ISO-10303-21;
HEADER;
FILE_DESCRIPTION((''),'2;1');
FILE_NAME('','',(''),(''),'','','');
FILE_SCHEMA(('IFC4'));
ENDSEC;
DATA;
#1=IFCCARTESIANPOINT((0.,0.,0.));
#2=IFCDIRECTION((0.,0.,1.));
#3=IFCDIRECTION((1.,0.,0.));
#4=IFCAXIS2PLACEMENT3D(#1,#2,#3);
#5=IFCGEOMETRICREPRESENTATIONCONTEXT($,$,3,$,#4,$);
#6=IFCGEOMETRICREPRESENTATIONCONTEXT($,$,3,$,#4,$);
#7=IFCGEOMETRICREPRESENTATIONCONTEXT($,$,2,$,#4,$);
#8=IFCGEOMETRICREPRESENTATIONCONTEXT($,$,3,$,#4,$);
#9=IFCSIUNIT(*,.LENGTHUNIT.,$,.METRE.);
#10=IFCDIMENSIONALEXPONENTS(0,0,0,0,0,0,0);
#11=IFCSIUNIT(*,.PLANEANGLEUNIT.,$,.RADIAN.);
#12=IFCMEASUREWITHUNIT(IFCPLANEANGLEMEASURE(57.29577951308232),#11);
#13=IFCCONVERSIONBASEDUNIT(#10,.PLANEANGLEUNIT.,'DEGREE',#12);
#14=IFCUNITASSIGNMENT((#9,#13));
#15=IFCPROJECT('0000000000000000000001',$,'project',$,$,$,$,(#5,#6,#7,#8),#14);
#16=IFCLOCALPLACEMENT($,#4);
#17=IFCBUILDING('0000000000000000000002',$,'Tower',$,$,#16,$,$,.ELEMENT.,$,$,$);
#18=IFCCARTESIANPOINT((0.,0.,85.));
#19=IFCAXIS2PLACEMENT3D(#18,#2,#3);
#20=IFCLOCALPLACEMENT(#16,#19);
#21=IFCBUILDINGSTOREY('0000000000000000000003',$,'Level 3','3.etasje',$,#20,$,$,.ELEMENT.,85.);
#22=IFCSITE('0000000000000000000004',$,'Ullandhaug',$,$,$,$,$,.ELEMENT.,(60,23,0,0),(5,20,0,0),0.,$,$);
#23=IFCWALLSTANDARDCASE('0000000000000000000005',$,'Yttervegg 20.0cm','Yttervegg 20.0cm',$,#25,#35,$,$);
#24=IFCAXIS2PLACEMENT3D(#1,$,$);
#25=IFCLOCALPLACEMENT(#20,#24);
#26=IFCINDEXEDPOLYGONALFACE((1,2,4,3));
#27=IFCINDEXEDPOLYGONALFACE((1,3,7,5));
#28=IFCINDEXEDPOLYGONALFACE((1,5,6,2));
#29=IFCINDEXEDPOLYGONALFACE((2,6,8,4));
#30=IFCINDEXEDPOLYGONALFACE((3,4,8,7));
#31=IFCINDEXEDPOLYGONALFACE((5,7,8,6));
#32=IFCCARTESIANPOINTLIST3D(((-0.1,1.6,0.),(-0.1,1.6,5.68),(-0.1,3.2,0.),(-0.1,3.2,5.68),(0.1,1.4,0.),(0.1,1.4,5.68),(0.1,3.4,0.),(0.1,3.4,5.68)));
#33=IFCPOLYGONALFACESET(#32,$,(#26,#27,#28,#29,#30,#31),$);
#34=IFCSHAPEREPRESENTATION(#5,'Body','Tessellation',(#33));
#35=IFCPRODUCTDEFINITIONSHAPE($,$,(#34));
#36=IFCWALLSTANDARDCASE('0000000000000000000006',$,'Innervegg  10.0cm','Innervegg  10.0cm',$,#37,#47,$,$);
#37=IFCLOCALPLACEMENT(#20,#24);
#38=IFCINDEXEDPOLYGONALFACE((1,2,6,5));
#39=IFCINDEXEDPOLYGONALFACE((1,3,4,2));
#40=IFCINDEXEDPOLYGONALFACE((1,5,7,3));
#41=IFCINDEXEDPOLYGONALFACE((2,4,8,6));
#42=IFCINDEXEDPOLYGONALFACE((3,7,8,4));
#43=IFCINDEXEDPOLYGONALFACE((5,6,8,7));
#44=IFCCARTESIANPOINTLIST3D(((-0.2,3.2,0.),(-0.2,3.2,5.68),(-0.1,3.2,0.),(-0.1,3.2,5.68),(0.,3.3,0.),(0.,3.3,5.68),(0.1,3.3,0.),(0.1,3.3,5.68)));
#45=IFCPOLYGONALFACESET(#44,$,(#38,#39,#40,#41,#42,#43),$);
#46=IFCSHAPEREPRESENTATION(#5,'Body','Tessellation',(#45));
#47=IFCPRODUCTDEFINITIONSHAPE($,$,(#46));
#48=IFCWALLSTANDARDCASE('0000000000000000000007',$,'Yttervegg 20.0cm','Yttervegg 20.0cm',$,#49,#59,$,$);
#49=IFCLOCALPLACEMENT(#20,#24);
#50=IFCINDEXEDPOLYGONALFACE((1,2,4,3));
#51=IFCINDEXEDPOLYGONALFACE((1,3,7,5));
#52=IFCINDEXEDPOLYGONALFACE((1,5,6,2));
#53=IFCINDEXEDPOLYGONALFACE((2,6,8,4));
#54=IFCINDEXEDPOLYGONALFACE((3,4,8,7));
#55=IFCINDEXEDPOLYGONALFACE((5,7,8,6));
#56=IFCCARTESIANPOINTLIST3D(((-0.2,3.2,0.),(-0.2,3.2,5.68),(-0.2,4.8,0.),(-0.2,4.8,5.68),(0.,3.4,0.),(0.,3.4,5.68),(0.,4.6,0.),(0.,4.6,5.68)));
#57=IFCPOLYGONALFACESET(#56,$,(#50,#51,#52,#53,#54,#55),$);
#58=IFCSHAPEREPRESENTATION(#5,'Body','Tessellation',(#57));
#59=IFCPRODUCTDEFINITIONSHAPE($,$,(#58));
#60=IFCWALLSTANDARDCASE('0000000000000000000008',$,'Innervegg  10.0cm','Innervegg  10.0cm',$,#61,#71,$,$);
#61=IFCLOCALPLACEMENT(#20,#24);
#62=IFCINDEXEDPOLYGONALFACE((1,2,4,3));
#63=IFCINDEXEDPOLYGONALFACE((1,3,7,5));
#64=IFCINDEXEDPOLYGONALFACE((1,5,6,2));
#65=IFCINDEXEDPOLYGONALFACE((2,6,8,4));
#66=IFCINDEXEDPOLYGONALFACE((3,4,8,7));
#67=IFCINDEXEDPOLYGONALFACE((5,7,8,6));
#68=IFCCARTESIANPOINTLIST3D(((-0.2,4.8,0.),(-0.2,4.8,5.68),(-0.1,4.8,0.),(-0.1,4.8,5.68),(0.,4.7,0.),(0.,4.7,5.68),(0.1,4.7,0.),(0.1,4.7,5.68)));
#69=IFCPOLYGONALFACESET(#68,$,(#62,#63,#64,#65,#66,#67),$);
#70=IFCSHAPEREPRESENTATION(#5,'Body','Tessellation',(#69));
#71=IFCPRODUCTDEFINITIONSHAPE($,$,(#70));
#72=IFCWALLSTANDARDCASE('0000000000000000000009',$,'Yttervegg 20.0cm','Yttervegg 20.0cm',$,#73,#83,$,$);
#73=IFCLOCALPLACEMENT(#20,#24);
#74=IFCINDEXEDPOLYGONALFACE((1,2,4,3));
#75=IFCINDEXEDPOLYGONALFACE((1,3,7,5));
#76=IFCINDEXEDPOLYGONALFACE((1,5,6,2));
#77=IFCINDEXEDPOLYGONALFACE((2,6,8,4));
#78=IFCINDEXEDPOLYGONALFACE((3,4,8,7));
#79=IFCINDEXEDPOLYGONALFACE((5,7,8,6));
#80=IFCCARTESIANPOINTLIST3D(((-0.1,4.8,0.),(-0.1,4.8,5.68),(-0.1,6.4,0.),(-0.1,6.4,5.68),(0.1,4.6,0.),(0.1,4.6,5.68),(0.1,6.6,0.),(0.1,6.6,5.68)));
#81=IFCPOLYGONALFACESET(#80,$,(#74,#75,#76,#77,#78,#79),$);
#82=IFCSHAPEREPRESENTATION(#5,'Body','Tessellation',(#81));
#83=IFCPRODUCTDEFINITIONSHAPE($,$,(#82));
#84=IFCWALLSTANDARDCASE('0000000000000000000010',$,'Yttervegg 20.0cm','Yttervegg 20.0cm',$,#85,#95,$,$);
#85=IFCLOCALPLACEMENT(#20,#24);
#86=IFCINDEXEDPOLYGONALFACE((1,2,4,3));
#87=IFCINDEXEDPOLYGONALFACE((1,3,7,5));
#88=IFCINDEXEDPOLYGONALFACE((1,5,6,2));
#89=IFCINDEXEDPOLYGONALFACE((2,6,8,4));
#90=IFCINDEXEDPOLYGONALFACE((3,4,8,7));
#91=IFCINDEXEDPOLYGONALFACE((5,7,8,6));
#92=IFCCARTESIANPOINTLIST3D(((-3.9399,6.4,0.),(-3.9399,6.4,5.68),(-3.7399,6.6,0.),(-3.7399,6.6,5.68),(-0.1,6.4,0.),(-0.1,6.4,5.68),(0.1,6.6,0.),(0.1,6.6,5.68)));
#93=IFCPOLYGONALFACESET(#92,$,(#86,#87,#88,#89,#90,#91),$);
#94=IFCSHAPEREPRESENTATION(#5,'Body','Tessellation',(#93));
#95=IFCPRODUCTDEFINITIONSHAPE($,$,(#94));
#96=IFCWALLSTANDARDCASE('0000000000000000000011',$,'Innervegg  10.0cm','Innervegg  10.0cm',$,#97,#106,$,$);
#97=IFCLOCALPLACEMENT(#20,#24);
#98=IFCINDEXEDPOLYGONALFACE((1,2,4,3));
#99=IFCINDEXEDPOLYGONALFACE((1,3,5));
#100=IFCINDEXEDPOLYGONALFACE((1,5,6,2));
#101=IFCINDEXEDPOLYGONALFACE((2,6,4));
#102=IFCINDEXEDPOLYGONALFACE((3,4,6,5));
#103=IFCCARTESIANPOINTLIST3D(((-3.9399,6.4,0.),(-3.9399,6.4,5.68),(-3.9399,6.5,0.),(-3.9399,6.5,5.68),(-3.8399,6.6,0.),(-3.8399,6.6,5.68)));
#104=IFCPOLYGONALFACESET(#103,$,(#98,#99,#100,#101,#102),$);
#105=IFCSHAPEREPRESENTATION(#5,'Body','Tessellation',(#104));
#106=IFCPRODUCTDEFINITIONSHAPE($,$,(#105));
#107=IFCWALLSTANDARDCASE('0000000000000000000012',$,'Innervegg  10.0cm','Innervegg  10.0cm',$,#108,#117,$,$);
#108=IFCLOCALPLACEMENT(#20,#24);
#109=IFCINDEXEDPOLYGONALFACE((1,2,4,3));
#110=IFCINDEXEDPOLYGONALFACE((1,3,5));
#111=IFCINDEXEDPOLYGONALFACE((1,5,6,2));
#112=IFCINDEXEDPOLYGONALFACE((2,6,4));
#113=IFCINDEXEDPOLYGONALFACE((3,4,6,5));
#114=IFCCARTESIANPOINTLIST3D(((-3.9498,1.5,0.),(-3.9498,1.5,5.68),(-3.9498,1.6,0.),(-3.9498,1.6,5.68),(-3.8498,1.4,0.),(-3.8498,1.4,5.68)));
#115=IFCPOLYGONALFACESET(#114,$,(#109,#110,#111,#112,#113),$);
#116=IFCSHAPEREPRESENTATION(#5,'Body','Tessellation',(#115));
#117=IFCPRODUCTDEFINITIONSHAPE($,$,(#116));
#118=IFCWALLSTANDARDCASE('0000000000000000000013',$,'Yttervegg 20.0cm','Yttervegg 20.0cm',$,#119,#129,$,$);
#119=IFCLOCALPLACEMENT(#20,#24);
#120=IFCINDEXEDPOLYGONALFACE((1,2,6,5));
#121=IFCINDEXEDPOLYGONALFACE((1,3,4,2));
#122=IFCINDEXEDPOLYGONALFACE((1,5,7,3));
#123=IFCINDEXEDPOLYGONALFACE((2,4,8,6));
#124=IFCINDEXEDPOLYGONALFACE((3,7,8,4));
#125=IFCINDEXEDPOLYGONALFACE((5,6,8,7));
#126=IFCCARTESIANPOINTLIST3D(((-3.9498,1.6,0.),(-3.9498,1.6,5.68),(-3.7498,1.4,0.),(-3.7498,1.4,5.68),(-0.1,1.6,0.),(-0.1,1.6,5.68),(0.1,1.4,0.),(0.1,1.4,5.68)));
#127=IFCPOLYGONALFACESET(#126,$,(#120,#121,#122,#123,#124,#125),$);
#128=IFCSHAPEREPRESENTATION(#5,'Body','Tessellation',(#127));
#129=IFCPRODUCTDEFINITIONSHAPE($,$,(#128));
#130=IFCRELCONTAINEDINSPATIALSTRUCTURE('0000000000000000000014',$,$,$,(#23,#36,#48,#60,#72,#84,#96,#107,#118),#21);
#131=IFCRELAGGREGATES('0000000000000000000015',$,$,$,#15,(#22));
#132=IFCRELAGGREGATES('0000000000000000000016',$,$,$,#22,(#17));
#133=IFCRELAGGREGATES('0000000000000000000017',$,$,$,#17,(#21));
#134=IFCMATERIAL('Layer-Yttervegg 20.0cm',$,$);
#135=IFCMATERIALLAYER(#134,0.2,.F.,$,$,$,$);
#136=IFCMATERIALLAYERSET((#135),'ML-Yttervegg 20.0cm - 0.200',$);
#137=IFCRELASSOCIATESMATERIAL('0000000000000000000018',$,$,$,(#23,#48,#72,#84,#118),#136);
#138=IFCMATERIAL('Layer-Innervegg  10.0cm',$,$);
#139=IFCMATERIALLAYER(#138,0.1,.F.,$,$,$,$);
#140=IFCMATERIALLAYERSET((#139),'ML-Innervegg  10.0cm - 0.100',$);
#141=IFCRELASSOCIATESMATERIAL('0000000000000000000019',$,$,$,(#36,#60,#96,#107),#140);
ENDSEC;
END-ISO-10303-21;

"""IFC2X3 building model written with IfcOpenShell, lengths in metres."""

from ifc_helpers import new_model, entity, si_unit, converted_unit, frame, origin_with_axes, place, context, project, spatial, polyline, outline, extrude, material, layer, layer_set, layer_usage, element, save


model = new_model("IFC2X3")

# Units and contexts
context_of_model_1 = context(None, 3, world=origin_with_axes())
context_of_model_2 = context(None, 3, world=origin_with_axes())
context_of_model_3 = context(None, 2, world=origin_with_axes())
context_of_model_4 = context(None, 3, world=origin_with_axes())
ifc_project = project(units=[si_unit("LENGTHUNIT", "METRE"), converted_unit("PLANEANGLEUNIT", "DEGREE", entity("IfcPlaneAngleMeasure", 57.29577951308232), si_unit("PLANEANGLEUNIT", "RADIAN"), dimensions=[0, 0, 0, 0, 0, 0, 0])], contexts=[context_of_model_1, context_of_model_2, context_of_model_3, context_of_model_4])

# Site, building, storey
site = spatial("IfcSite", under=ifc_project, Name="Ullandhaug", CompositionType="ELEMENT", RefLatitude=(60, 23, 0, 0), RefLongitude=(5, 20, 0, 0), RefElevation=0.0)
building_placement = place(None, origin_with_axes())
building = spatial("IfcBuilding", under=site, at=building_placement, Name="Tower", CompositionType="ELEMENT")
storey_placement = place(building_placement, frame((0.0, 0.0, 85.0), z_axis=(0.0, 0.0, 1.0), x_axis=(1.0, 0.0, 0.0)))
storey = spatial("IfcBuildingStorey", under=building, at=storey_placement, Name="Level 3", Description="3.etasje", CompositionType="ELEMENT", Elevation=85.0)

# Shared definitions
ifc_material_1 = material(Name="Layer-Yttervegg 20.0cm")
ifc_layer_1 = layer(ifc_material_1, 0.2, ventilated=False)
ifc_layer_set_1 = layer_set([ifc_layer_1], Name="ML-Yttervegg 20.0cm - 0.200")
ifc_layer_usage_1 = layer_usage(ifc_layer_set_1, "AXIS2", "POSITIVE", 0.0)

# Walls
wall_1_placement = place(storey_placement, frame((0.1, 1.4, 0.0), z_axis=(0.0, 0.0, 1.0), x_axis=(0.0, 1.0, 0.0)))
element("IfcWallStandardCase", 1, at=wall_1_placement, inside=storey, material=ifc_layer_usage_1, Name="Yttervegg 20.0cm", Description="Yttervegg 20.0cm", context=context_of_model_1, shape_type="SweptSolid", body=[
    extrude(outline(polyline([(0.0, 0.0), (2.0, 0.0), (1.8, 0.2), (0.2, 0.2), (0.0, 0.0)])), frame((0.0, 0.0, 0.0), z_axis=(0.0, 0.0, 1.0), x_axis=(1.0, 0.0, 0.0)), (0.0, 0.0, 1.0), 5.68),
])
ifc_material_2 = material(Name="Layer-Innervegg  10.0cm")
ifc_layer_2 = layer(ifc_material_2, 0.1, ventilated=False)
ifc_layer_set_2 = layer_set([ifc_layer_2], Name="ML-Innervegg  10.0cm - 0.100")
ifc_layer_usage_2 = layer_usage(ifc_layer_set_2, "AXIS2", "POSITIVE", 0.0)
wall_2_placement = place(storey_placement, frame((0.1, 3.3, 0.0), z_axis=(0.0, 0.0, 1.0), x_axis=(-1.0, 0.0, 0.0)))
element("IfcWallStandardCase", 2, at=wall_2_placement, inside=storey, material=ifc_layer_usage_2, Name="Innervegg  10.0cm", Description="Innervegg  10.0cm", context=context_of_model_1, shape_type="SweptSolid", body=[
    extrude(outline(polyline([(0.0, 0.0), (0.1, 0.0), (0.3, 0.1), (0.2, 0.1), (0.0, 0.0)])), frame((0.0, 0.0, 0.0), z_axis=(0.0, 0.0, 1.0), x_axis=(1.0, 0.0, 0.0)), (0.0, 0.0, 1.0), 5.68),
])
wall_3_placement = place(storey_placement, frame((0.0, 3.4, 0.0), z_axis=(0.0, 0.0, 1.0), x_axis=(0.0, 1.0, 0.0)))
element("IfcWallStandardCase", 3, at=wall_3_placement, inside=storey, material=ifc_layer_usage_1, Name="Yttervegg 20.0cm", Description="Yttervegg 20.0cm", context=context_of_model_1, shape_type="SweptSolid", body=[
    extrude(outline(polyline([(0.0, 0.0), (1.2, 0.0), (1.4, 0.2), (-0.2, 0.2), (0.0, 0.0)])), frame((0.0, 0.0, 0.0), z_axis=(0.0, 0.0, 1.0), x_axis=(1.0, 0.0, 0.0)), (0.0, 0.0, 1.0), 5.68),
])
wall_4_placement = place(storey_placement, frame((0.0, 4.7, 0.0), z_axis=(0.0, 0.0, 1.0), x_axis=(1.0, 0.0, 0.0)))
element("IfcWallStandardCase", 4, at=wall_4_placement, inside=storey, material=ifc_layer_usage_2, Name="Innervegg  10.0cm", Description="Innervegg  10.0cm", context=context_of_model_1, shape_type="SweptSolid", body=[
    extrude(outline(polyline([(0.0, 0.0), (0.1, 0.0), (-0.1, 0.1), (-0.2, 0.1), (0.0, 0.0)])), origin_with_axes(), (0.0, 0.0, 1.0), 5.68),
])
wall_5_placement = place(storey_placement, frame((0.1, 4.6, 0.0), z_axis=(0.0, 0.0, 1.0), x_axis=(0.0, 1.0, 0.0)))
element("IfcWallStandardCase", 5, at=wall_5_placement, inside=storey, material=ifc_layer_usage_1, Name="Yttervegg 20.0cm", Description="Yttervegg 20.0cm", context=context_of_model_1, shape_type="SweptSolid", body=[
    extrude(outline(polyline([(0.0, 0.0), (2.0, 0.0), (1.8, 0.2), (0.2, 0.2), (0.0, 0.0)])), frame((0.0, 0.0, 0.0), z_axis=(0.0, 0.0, 1.0), x_axis=(1.0, 0.0, 0.0)), (0.0, 0.0, 1.0), 5.68),
])
wall_6_placement = place(storey_placement, frame((0.1, 6.6, 0.0), z_axis=(0.0, 0.0, 1.0), x_axis=(-1.0, 0.0, 0.0)))
element("IfcWallStandardCase", 6, at=wall_6_placement, inside=storey, material=ifc_layer_usage_1, Name="Yttervegg 20.0cm", Description="Yttervegg 20.0cm", context=context_of_model_1, shape_type="SweptSolid", body=[
    extrude(outline(polyline([(0.0, 0.0), (3.8399, 0.0), (4.0399, 0.2), (0.2, 0.2), (0.0, 0.0)])), frame((0.0, 0.0, 0.0), z_axis=(0.0, 0.0, 1.0), x_axis=(1.0, 0.0, 0.0)), (0.0, 0.0, 1.0), 5.68),
])
wall_7_placement = place(storey_placement, frame((-3.8399, 6.6, 0.0), z_axis=(0.0, 0.0, 1.0), x_axis=(0.0, 1.0, 0.0)))
element("IfcWallStandardCase", 7, at=wall_7_placement, inside=storey, material=ifc_layer_usage_2, Name="Innervegg  10.0cm", Description="Innervegg  10.0cm", context=context_of_model_1, shape_type="SweptSolid", body=[
    extrude(outline(polyline([(0.0, 0.0), (0.0, 0.0), (0.1414, 0.0), (0.2121, 0.0707), (0.0, 0.0)])), frame((0.0, 0.0, 0.0), z_axis=(0.0, 0.0, 1.0), x_axis=(-0.707105, 0.707108, 0.0)), (0.0, 0.0, 1.0), 5.68),
])
wall_8_placement = place(storey_placement, frame((-3.8498, 1.4, 0.0), z_axis=(0.0, 0.0, 1.0), x_axis=(1.0, 0.0, 0.0)))
element("IfcWallStandardCase", 8, at=wall_8_placement, inside=storey, material=ifc_layer_usage_2, Name="Innervegg  10.0cm", Description="Innervegg  10.0cm", context=context_of_model_1, shape_type="SweptSolid", body=[
    extrude(outline(polyline([(0.0, 0.0), (0.0, 0.0), (0.2236, 0.0), (0.1342, 0.0447), (0.0, 0.0)])), frame((0.0, 0.0, 0.0), z_axis=(0.0, 0.0, 1.0), x_axis=(-0.447213, 0.894427, 0.0)), (0.0, 0.0, 1.0), 5.68),
])
wall_9_placement = place(storey_placement, frame((-3.7498, 1.4, 0.0), z_axis=(0.0, 0.0, 1.0), x_axis=(1.0, 0.0, 0.0)))
element("IfcWallStandardCase", 9, at=wall_9_placement, inside=storey, material=ifc_layer_usage_1, Name="Yttervegg 20.0cm", Description="Yttervegg 20.0cm", context=context_of_model_1, shape_type="SweptSolid", body=[
    extrude(outline(polyline([(0.0, 0.0), (3.8498, 0.0), (3.6498, 0.2), (-0.2, 0.2), (0.0, 0.0)])), origin_with_axes(), (0.0, 0.0, 1.0), 5.68),
])

save(model, "model.ifc")
